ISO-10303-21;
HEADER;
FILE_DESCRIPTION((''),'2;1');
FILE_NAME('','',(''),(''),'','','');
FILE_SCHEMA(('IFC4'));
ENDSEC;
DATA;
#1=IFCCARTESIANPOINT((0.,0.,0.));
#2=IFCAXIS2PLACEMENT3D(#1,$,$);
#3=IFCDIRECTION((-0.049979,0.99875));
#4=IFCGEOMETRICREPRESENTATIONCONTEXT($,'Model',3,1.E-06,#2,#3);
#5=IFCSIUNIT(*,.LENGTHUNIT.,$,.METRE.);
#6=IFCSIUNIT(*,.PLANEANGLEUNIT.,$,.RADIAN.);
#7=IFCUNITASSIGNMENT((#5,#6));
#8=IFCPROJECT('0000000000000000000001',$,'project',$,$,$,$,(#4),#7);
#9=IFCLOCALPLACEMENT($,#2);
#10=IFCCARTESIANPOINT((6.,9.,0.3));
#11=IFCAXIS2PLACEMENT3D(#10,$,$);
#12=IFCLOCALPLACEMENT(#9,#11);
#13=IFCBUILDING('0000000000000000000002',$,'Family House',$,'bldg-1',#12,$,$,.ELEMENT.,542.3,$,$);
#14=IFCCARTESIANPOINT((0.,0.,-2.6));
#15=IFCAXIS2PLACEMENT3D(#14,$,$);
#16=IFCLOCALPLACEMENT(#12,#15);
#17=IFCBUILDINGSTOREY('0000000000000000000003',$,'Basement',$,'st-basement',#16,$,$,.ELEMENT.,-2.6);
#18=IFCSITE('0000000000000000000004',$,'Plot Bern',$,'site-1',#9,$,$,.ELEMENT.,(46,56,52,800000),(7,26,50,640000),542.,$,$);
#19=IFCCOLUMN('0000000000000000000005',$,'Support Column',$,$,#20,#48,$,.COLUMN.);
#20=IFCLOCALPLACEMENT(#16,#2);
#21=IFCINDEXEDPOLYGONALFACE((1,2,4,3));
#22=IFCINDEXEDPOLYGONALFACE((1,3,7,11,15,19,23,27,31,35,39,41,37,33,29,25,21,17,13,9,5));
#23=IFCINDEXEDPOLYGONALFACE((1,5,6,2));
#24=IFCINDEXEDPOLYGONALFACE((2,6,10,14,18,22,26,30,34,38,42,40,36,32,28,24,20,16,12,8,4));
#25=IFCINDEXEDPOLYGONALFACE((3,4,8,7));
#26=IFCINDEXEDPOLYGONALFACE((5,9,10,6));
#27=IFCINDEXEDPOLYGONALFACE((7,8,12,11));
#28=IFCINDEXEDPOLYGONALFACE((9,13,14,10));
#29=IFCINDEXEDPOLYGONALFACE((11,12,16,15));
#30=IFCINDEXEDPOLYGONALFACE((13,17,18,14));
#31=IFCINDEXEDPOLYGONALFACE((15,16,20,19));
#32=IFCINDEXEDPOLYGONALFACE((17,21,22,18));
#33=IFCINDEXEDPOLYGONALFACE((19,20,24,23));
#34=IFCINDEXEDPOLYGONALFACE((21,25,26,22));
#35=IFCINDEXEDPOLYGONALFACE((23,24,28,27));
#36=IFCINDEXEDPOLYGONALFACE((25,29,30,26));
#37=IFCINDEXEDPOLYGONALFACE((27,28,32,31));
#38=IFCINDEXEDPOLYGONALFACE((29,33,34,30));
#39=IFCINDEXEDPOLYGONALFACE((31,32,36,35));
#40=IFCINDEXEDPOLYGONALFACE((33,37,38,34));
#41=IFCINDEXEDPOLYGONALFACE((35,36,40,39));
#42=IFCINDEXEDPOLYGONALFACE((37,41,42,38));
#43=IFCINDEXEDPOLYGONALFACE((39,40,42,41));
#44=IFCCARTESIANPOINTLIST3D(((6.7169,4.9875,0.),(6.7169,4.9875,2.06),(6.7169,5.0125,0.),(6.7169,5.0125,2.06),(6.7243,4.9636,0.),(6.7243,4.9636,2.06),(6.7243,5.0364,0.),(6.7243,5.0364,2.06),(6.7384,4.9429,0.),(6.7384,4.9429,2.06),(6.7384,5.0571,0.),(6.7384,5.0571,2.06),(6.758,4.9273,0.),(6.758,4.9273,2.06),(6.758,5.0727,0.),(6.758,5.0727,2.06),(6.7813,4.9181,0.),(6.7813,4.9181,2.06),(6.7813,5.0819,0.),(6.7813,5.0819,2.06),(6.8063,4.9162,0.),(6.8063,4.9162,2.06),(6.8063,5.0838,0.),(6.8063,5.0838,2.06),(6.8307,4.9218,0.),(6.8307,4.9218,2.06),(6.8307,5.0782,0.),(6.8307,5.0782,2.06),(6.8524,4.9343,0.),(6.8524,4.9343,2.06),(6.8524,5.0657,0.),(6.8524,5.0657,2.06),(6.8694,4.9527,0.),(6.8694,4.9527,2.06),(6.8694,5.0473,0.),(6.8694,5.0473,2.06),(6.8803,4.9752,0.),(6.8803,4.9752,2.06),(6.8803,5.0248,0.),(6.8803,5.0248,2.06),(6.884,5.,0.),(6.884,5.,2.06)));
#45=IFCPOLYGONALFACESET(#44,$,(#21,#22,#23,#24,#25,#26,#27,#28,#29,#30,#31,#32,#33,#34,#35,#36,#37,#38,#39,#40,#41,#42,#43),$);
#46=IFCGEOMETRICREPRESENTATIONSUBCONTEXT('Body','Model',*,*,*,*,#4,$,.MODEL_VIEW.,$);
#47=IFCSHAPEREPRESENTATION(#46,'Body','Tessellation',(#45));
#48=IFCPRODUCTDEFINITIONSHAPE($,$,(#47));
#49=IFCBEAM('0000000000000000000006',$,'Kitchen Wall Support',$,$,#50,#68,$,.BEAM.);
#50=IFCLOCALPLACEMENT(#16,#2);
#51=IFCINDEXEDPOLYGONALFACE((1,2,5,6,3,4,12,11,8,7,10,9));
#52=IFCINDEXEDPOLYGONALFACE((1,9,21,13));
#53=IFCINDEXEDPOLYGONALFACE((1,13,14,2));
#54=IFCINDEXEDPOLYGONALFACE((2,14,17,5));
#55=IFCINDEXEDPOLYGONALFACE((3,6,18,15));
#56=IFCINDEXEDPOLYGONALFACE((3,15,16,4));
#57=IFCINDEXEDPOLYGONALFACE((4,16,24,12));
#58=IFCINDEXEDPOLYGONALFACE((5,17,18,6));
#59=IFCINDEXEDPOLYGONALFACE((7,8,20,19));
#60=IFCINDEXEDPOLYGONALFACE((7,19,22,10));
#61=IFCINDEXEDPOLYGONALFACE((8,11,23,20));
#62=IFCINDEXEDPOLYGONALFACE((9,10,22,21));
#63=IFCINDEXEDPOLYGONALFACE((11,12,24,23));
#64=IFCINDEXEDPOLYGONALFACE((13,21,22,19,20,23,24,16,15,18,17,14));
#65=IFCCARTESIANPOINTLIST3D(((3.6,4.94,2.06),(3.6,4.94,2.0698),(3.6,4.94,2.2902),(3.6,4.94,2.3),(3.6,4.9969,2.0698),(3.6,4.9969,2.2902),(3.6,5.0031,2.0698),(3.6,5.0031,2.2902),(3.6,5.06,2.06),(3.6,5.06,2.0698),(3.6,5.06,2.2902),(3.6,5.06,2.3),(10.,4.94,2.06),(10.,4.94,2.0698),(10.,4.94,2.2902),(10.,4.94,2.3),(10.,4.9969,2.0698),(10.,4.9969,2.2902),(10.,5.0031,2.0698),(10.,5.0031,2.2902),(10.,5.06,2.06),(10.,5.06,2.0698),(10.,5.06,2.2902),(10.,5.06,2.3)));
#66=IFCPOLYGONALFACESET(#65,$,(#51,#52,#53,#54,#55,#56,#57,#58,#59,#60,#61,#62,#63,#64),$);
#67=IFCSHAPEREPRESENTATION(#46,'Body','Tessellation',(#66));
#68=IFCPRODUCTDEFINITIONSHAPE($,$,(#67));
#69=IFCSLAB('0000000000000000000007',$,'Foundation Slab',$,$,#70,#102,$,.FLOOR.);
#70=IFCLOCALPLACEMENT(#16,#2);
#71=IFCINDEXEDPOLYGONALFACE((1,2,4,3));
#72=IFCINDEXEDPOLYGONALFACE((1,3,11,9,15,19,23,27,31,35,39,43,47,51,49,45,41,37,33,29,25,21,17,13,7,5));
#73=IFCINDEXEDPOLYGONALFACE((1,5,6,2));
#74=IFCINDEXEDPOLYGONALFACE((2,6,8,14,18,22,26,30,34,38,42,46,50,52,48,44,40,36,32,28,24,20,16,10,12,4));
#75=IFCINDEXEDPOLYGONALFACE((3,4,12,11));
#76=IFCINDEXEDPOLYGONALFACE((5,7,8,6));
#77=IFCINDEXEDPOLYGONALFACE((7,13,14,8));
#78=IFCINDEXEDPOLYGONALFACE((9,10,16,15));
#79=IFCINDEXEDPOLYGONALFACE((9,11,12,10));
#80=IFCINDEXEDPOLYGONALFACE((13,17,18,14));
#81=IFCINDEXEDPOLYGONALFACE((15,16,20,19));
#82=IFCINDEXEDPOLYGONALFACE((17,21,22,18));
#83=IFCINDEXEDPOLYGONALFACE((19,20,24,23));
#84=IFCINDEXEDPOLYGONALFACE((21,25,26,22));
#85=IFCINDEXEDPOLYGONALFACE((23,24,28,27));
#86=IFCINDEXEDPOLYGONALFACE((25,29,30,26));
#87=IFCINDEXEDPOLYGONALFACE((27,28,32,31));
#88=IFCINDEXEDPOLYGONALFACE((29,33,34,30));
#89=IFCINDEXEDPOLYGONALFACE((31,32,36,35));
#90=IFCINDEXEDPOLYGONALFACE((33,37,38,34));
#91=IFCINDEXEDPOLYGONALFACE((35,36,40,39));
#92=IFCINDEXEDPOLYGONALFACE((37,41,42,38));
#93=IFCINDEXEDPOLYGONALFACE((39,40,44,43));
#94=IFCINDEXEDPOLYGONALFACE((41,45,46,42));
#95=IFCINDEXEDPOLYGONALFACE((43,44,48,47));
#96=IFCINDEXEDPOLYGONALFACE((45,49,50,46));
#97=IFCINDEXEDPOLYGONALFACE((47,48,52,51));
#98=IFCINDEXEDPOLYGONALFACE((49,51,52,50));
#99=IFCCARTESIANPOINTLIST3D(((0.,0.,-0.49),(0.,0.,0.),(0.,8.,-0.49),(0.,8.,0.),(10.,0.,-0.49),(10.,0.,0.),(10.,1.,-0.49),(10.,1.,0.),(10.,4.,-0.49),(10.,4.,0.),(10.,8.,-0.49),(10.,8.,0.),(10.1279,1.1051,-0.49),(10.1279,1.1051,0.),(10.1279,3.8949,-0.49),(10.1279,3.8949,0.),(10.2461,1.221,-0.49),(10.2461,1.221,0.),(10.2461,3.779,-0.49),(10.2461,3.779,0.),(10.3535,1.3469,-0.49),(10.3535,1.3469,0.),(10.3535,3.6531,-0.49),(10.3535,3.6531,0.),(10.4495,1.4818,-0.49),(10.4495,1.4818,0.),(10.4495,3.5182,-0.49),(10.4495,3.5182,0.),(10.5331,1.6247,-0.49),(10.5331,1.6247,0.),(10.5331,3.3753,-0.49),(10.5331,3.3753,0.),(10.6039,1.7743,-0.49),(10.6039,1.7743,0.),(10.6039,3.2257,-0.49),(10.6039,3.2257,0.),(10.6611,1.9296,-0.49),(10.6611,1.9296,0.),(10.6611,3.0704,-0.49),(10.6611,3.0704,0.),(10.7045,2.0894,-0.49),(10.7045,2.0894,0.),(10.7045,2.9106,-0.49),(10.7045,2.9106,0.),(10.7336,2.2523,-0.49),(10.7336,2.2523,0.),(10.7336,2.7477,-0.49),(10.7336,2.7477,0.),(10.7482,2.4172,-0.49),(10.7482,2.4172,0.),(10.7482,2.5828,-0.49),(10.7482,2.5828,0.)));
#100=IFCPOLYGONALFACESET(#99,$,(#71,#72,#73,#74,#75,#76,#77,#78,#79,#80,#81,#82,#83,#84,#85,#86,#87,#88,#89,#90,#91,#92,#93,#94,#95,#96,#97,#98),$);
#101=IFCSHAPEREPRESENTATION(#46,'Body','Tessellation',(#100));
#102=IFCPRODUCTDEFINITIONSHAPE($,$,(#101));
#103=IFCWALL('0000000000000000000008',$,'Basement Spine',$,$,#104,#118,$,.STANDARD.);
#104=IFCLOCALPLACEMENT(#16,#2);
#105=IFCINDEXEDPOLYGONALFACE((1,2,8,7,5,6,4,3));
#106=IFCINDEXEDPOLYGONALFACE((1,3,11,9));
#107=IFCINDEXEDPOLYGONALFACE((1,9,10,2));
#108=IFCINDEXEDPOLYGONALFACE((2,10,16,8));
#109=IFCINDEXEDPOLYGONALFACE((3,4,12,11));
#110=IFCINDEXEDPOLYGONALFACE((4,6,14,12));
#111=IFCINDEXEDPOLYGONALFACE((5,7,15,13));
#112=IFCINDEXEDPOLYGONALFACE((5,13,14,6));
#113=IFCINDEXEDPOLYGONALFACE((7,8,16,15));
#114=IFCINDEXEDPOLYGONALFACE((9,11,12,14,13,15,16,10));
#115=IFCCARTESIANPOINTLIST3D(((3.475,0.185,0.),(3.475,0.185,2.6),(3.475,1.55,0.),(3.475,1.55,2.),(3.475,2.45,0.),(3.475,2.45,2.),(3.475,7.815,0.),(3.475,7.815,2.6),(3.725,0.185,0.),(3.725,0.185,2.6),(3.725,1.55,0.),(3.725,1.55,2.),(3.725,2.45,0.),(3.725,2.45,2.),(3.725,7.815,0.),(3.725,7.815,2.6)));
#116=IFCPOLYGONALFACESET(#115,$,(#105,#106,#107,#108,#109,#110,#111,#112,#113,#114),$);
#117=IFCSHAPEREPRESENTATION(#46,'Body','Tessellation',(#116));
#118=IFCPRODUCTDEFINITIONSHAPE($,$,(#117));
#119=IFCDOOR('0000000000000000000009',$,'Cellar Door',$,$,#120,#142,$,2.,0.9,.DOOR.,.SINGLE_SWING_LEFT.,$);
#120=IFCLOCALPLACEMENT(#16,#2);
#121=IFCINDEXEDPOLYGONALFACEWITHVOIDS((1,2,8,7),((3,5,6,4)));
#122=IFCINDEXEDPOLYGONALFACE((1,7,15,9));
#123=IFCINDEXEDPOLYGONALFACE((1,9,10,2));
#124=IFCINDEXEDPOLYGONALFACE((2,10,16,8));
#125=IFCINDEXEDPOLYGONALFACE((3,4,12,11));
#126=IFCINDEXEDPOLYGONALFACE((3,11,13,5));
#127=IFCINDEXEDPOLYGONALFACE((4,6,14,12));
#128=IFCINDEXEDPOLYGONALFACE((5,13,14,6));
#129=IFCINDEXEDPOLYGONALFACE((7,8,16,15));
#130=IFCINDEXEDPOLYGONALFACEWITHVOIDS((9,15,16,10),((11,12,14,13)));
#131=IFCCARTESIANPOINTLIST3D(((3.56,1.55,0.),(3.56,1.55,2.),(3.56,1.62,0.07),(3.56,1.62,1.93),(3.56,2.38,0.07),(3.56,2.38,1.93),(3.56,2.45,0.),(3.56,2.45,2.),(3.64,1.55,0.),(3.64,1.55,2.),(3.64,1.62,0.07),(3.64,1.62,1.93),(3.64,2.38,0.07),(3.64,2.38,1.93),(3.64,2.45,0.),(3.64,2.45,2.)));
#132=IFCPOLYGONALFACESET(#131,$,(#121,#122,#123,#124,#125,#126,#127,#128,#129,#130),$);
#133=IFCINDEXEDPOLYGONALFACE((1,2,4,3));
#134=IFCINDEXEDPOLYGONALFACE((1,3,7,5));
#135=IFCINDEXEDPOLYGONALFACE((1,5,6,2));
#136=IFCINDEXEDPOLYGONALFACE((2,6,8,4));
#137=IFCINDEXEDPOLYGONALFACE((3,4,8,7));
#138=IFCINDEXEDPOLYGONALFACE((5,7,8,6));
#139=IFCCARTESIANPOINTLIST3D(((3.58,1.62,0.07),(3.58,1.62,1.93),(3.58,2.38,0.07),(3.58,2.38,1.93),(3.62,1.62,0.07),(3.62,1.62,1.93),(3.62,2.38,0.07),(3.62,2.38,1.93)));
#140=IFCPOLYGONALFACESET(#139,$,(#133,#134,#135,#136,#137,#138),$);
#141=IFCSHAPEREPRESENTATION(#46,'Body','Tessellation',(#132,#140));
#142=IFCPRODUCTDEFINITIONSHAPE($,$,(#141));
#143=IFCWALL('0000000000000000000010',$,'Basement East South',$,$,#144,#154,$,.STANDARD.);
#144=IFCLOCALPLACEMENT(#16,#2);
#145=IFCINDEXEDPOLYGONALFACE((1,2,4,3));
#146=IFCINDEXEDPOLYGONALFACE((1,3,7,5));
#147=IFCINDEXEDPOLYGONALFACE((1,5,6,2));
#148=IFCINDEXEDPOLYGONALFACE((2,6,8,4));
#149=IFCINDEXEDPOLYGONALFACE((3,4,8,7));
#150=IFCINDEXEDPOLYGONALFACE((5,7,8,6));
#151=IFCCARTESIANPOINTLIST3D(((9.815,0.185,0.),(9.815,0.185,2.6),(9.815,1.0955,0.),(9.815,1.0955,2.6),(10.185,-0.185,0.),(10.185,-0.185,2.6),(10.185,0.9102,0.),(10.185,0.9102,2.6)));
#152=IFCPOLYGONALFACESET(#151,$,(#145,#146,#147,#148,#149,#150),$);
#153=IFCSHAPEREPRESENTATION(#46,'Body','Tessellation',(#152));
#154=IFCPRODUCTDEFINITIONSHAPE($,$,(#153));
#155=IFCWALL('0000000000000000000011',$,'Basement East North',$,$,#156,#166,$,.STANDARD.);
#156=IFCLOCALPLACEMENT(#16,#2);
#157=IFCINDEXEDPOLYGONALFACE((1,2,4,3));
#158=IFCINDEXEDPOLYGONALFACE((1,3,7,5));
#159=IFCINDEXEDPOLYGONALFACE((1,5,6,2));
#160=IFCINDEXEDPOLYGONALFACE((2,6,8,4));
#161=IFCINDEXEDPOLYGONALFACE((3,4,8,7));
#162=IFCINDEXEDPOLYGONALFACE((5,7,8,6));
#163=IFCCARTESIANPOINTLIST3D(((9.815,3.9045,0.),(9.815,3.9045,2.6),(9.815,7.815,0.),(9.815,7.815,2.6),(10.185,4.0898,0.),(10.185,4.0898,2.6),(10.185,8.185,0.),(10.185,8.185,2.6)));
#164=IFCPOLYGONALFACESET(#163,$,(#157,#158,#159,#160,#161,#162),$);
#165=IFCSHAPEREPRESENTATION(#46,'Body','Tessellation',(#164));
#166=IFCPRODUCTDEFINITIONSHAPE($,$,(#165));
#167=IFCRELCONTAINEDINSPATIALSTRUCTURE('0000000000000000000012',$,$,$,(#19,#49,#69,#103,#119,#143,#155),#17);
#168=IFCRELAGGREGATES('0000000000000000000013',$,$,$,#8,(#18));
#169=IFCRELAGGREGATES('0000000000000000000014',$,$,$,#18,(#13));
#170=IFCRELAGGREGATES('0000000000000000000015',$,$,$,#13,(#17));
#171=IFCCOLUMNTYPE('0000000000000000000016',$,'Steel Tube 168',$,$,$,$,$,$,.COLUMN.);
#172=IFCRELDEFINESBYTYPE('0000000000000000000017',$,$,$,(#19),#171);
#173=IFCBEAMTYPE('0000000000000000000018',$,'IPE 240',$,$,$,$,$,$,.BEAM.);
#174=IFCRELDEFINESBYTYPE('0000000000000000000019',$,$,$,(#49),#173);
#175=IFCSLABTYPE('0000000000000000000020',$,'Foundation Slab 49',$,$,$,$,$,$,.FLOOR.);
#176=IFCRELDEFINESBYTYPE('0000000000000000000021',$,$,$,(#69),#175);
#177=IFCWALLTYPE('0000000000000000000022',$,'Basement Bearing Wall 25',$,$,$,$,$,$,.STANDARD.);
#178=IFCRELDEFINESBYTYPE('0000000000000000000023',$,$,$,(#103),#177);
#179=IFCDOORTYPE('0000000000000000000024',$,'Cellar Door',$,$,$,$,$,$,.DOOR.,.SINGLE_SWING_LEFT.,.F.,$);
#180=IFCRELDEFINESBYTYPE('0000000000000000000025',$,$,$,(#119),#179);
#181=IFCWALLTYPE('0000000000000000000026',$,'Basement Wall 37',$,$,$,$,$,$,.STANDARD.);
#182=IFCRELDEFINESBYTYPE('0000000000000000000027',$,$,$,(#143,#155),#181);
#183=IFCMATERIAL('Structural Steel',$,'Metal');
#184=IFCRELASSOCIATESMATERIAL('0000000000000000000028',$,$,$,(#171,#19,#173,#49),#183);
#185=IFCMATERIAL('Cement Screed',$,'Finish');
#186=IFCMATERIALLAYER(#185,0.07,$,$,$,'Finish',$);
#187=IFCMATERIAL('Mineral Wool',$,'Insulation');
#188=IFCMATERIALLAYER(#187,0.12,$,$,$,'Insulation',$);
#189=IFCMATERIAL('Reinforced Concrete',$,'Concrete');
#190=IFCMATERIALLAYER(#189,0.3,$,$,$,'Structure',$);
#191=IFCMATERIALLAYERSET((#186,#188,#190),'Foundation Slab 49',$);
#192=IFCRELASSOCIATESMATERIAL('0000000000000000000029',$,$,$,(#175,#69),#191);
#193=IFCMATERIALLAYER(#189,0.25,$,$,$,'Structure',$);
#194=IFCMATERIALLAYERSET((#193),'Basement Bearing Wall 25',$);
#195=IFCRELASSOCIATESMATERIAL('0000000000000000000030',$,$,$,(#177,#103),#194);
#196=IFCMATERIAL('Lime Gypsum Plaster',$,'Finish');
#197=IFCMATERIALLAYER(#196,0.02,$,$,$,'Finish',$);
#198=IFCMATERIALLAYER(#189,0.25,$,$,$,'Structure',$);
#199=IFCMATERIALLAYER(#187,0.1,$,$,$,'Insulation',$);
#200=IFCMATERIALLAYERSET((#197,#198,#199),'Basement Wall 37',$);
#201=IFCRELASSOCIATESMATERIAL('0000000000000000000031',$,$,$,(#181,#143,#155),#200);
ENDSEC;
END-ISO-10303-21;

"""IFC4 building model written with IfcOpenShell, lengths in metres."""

from ifc_helpers import new_model, si_unit, point, direction, frame, frame_2d, origin, origin_2d, place, context, subcontext, project, spatial, polyline, circle_curve, trimmed, segment, composite_curve, rectangle, circle, i_section, outline, extrude, material, layer, layer_set, layer_usage, type_object, element, fill, save


model = new_model("IFC4")

# Units and contexts
model_context = context("Model", 3, precision=1e-06, world=origin(), true_north=direction((-0.049979, 0.99875)))
body_context = subcontext(model_context, "Body", "Model", "MODEL_VIEW")
ifc_project = project(units=[si_unit("LENGTHUNIT", "METRE"), si_unit("PLANEANGLEUNIT", "RADIAN")], contexts=[model_context])

# Site, building, storey
site_placement = place(None, origin())
site = spatial("IfcSite", under=ifc_project, at=site_placement, Name="Plot Bern", ObjectType="site-1", CompositionType="ELEMENT", RefLatitude=(46, 56, 52, 800000), RefLongitude=(7, 26, 50, 640000), RefElevation=542.0)
building_placement = place(site_placement, frame((6.0, 9.0, 0.3)))
building = spatial("IfcBuilding", under=site, at=building_placement, Name="Family House", ObjectType="bldg-1", CompositionType="ELEMENT", ElevationOfRefHeight=542.3)
storey_placement = place(building_placement, frame((0.0, 0.0, -2.6)))
storey = spatial("IfcBuildingStorey", under=building, at=storey_placement, Name="Basement", ObjectType="st-basement", CompositionType="ELEMENT", Elevation=-2.6)

# Column
ifc_material_1 = material(Name="Structural Steel", Category="Metal")
column_type = type_object("IfcColumnType", Name="Steel Tube 168", PredefinedType="COLUMN", material=ifc_material_1)
column_placement = place(storey_placement, frame((6.8, 5.0, 0.0)))
element("IfcColumn", 1, at=column_placement, inside=storey, type_object=column_type, material=ifc_material_1, Name="Support Column", PredefinedType="COLUMN", context=body_context, shape_type="SweptSolid", body=[
    extrude(circle(Radius=0.084, at=origin_2d()), origin(), (0.0, 0.0, 1.0), 2.06),
])

# Beam
beam_type = type_object("IfcBeamType", Name="IPE 240", PredefinedType="BEAM", material=ifc_material_1)
beam_placement = place(storey_placement, frame((3.6, 5.0, 2.18), z_axis=(1.0, 0.0, 0.0), x_axis=(0.0, 1.0, 0.0)))
element("IfcBeam", 2, at=beam_placement, inside=storey, type_object=beam_type, material=ifc_material_1, Name="Kitchen Wall Support", PredefinedType="BEAM", context=body_context, shape_type="SweptSolid", body=[
    extrude(i_section(OverallWidth=0.12, OverallDepth=0.24, WebThickness=0.0062, FlangeThickness=0.0098, at=origin_2d()), origin(), (0.0, 0.0, 1.0), 6.4),
])

# Slab
ifc_material_2 = material(Name="Cement Screed", Category="Finish")
ifc_layer_1 = layer(ifc_material_2, 0.07, Category="Finish")
ifc_material_3 = material(Name="Mineral Wool", Category="Insulation")
ifc_layer_2 = layer(ifc_material_3, 0.12, Category="Insulation")
ifc_material_4 = material(Name="Reinforced Concrete", Category="Concrete")
ifc_layer_3 = layer(ifc_material_4, 0.3, Category="Structure")
ifc_layer_set_1 = layer_set([ifc_layer_1, ifc_layer_2, ifc_layer_3], Name="Foundation Slab 49")
ifc_layer_usage_1 = layer_usage(ifc_layer_set_1, "AXIS3", "NEGATIVE", 0.49)
slab_type = type_object("IfcSlabType", Name="Foundation Slab 49", PredefinedType="FLOOR", material=ifc_layer_set_1)
slab_placement = place(storey_placement, frame((0.0, 0.0, -0.49)))
element("IfcSlab", 3, at=slab_placement, inside=storey, type_object=slab_type, material=ifc_layer_usage_1, Name="Foundation Slab", PredefinedType="FLOOR", context=body_context, shape_type="SweptSolid", body=[
    extrude(outline(composite_curve([segment(polyline([(0.0, 0.0), (10.0, 0.0)]), True, "CONTINUOUS"), segment(polyline([(10.0, 0.0), (10.0, 1.0)]), True, "CONTINUOUS"), segment(trimmed(circle_curve(frame_2d((8.875, 2.5)), 1.875), [point((10.0, 1.0))], [point((10.0, 4.0))], True, "CARTESIAN"), True, "CONTINUOUS"), segment(polyline([(10.0, 4.0), (10.0, 8.0)]), True, "CONTINUOUS"), segment(polyline([(10.0, 8.0), (0.0, 8.0)]), True, "CONTINUOUS"), segment(polyline([(0.0, 8.0), (0.0, 0.0)]), True, "CONTINUOUS")], self_intersect=False)), origin(), (0.0, 0.0, 1.0), 0.49),
])

# Wall, opening, door
ifc_layer_4 = layer(ifc_material_4, 0.25, Category="Structure")
ifc_layer_set_2 = layer_set([ifc_layer_4], Name="Basement Bearing Wall 25")
ifc_layer_usage_2 = layer_usage(ifc_layer_set_2, "AXIS2", "NEGATIVE", 0.125)
wall_type_1 = type_object("IfcWallType", Name="Basement Bearing Wall 25", PredefinedType="STANDARD", material=ifc_layer_set_2)
wall_1_placement = place(storey_placement, origin())
wall_1 = element("IfcWall", 4, at=wall_1_placement, inside=storey, type_object=wall_type_1, material=ifc_layer_usage_2, Name="Basement Spine", PredefinedType="STANDARD", context=body_context, shape_type="SweptSolid", body=[
    extrude(outline(polyline([(3.725, 0.185), (3.725, 7.815), (3.475, 7.815), (3.475, 0.185), (3.725, 0.185)])), origin(), (0.0, 0.0, 1.0), 2.6),
])
opening_1_placement = place(wall_1_placement, frame((3.6, 2.0, 0.0), z_axis=(0.0, 0.0, 1.0), x_axis=(0.0, 1.0, 0.0)))
opening_1 = element("IfcOpeningElement", 5, at=opening_1_placement, cuts=wall_1, PredefinedType="OPENING", context=body_context, shape_type="SweptSolid", body=[
    extrude(rectangle(XDim=0.9, YDim=0.25, at=origin_2d()), origin(), (0.0, 0.0, 1.0), 2.0),
])
door_type = type_object("IfcDoorType", Name="Cellar Door", OperationType="SINGLE_SWING_LEFT", ParameterTakesPrecedence=False, PredefinedType="DOOR")
door_placement = place(opening_1_placement, frame((0.0, 0.0, 0.0), z_axis=(0.0, 1.0, 0.0), x_axis=(-1.0, 0.0, 0.0)))
door = element("IfcDoor", 6, at=door_placement, inside=storey, type_object=door_type, Name="Cellar Door", OperationType="SINGLE_SWING_LEFT", OverallHeight=2.0, OverallWidth=0.9, PredefinedType="DOOR", context=body_context, shape_type="SweptSolid", body=[
    extrude(outline(polyline([(-0.45, 0.0), (0.45, 0.0), (0.45, 2.0), (-0.45, 2.0), (-0.45, 0.0)]), holes=[polyline([(-0.38, 0.07), (0.38, 0.07), (0.38, 1.93), (-0.38, 1.93), (-0.38, 0.07)])]), frame((0.0, 0.0, -0.04)), (0.0, 0.0, 1.0), 0.08),
    extrude(rectangle(XDim=0.76, YDim=1.86, at=frame_2d((0.0, 1.0))), frame((0.0, 0.0, -0.02)), (0.0, 0.0, 1.0), 0.04),
])
fill(opening_1, door)

# Walls
ifc_material_5 = material(Name="Lime Gypsum Plaster", Category="Finish")
ifc_layer_5 = layer(ifc_material_5, 0.02, Category="Finish")
ifc_layer_6 = layer(ifc_material_4, 0.25, Category="Structure")
ifc_layer_7 = layer(ifc_material_3, 0.1, Category="Insulation")
ifc_layer_set_3 = layer_set([ifc_layer_5, ifc_layer_6, ifc_layer_7], Name="Basement Wall 37")
wall_type_2 = type_object("IfcWallType", Name="Basement Wall 37", PredefinedType="STANDARD", material=ifc_layer_set_3)
ifc_layer_usage_3 = layer_usage(ifc_layer_set_3, "AXIS2", "NEGATIVE", 0.185)
wall_2_placement = place(storey_placement, origin())
element("IfcWall", 7, at=wall_2_placement, inside=storey, type_object=wall_type_2, material=ifc_layer_usage_3, Name="Basement East South", PredefinedType="STANDARD", context=body_context, shape_type="SweptSolid", body=[
    extrude(outline(polyline([(10.185, -0.185), (10.185, 0.9102), (9.815, 1.0955), (9.815, 0.185), (10.185, -0.185)])), origin(), (0.0, 0.0, 1.0), 2.6),
])
ifc_layer_usage_4 = layer_usage(ifc_layer_set_3, "AXIS2", "NEGATIVE", 0.185)
wall_3_placement = place(storey_placement, origin())
element("IfcWall", 8, at=wall_3_placement, inside=storey, type_object=wall_type_2, material=ifc_layer_usage_4, Name="Basement East North", PredefinedType="STANDARD", context=body_context, shape_type="SweptSolid", body=[
    extrude(outline(polyline([(10.185, 4.0898), (10.185, 8.185), (9.815, 7.815), (9.815, 3.9045), (10.185, 4.0898)])), origin(), (0.0, 0.0, 1.0), 2.6),
])

save(model, "model.ifc")
